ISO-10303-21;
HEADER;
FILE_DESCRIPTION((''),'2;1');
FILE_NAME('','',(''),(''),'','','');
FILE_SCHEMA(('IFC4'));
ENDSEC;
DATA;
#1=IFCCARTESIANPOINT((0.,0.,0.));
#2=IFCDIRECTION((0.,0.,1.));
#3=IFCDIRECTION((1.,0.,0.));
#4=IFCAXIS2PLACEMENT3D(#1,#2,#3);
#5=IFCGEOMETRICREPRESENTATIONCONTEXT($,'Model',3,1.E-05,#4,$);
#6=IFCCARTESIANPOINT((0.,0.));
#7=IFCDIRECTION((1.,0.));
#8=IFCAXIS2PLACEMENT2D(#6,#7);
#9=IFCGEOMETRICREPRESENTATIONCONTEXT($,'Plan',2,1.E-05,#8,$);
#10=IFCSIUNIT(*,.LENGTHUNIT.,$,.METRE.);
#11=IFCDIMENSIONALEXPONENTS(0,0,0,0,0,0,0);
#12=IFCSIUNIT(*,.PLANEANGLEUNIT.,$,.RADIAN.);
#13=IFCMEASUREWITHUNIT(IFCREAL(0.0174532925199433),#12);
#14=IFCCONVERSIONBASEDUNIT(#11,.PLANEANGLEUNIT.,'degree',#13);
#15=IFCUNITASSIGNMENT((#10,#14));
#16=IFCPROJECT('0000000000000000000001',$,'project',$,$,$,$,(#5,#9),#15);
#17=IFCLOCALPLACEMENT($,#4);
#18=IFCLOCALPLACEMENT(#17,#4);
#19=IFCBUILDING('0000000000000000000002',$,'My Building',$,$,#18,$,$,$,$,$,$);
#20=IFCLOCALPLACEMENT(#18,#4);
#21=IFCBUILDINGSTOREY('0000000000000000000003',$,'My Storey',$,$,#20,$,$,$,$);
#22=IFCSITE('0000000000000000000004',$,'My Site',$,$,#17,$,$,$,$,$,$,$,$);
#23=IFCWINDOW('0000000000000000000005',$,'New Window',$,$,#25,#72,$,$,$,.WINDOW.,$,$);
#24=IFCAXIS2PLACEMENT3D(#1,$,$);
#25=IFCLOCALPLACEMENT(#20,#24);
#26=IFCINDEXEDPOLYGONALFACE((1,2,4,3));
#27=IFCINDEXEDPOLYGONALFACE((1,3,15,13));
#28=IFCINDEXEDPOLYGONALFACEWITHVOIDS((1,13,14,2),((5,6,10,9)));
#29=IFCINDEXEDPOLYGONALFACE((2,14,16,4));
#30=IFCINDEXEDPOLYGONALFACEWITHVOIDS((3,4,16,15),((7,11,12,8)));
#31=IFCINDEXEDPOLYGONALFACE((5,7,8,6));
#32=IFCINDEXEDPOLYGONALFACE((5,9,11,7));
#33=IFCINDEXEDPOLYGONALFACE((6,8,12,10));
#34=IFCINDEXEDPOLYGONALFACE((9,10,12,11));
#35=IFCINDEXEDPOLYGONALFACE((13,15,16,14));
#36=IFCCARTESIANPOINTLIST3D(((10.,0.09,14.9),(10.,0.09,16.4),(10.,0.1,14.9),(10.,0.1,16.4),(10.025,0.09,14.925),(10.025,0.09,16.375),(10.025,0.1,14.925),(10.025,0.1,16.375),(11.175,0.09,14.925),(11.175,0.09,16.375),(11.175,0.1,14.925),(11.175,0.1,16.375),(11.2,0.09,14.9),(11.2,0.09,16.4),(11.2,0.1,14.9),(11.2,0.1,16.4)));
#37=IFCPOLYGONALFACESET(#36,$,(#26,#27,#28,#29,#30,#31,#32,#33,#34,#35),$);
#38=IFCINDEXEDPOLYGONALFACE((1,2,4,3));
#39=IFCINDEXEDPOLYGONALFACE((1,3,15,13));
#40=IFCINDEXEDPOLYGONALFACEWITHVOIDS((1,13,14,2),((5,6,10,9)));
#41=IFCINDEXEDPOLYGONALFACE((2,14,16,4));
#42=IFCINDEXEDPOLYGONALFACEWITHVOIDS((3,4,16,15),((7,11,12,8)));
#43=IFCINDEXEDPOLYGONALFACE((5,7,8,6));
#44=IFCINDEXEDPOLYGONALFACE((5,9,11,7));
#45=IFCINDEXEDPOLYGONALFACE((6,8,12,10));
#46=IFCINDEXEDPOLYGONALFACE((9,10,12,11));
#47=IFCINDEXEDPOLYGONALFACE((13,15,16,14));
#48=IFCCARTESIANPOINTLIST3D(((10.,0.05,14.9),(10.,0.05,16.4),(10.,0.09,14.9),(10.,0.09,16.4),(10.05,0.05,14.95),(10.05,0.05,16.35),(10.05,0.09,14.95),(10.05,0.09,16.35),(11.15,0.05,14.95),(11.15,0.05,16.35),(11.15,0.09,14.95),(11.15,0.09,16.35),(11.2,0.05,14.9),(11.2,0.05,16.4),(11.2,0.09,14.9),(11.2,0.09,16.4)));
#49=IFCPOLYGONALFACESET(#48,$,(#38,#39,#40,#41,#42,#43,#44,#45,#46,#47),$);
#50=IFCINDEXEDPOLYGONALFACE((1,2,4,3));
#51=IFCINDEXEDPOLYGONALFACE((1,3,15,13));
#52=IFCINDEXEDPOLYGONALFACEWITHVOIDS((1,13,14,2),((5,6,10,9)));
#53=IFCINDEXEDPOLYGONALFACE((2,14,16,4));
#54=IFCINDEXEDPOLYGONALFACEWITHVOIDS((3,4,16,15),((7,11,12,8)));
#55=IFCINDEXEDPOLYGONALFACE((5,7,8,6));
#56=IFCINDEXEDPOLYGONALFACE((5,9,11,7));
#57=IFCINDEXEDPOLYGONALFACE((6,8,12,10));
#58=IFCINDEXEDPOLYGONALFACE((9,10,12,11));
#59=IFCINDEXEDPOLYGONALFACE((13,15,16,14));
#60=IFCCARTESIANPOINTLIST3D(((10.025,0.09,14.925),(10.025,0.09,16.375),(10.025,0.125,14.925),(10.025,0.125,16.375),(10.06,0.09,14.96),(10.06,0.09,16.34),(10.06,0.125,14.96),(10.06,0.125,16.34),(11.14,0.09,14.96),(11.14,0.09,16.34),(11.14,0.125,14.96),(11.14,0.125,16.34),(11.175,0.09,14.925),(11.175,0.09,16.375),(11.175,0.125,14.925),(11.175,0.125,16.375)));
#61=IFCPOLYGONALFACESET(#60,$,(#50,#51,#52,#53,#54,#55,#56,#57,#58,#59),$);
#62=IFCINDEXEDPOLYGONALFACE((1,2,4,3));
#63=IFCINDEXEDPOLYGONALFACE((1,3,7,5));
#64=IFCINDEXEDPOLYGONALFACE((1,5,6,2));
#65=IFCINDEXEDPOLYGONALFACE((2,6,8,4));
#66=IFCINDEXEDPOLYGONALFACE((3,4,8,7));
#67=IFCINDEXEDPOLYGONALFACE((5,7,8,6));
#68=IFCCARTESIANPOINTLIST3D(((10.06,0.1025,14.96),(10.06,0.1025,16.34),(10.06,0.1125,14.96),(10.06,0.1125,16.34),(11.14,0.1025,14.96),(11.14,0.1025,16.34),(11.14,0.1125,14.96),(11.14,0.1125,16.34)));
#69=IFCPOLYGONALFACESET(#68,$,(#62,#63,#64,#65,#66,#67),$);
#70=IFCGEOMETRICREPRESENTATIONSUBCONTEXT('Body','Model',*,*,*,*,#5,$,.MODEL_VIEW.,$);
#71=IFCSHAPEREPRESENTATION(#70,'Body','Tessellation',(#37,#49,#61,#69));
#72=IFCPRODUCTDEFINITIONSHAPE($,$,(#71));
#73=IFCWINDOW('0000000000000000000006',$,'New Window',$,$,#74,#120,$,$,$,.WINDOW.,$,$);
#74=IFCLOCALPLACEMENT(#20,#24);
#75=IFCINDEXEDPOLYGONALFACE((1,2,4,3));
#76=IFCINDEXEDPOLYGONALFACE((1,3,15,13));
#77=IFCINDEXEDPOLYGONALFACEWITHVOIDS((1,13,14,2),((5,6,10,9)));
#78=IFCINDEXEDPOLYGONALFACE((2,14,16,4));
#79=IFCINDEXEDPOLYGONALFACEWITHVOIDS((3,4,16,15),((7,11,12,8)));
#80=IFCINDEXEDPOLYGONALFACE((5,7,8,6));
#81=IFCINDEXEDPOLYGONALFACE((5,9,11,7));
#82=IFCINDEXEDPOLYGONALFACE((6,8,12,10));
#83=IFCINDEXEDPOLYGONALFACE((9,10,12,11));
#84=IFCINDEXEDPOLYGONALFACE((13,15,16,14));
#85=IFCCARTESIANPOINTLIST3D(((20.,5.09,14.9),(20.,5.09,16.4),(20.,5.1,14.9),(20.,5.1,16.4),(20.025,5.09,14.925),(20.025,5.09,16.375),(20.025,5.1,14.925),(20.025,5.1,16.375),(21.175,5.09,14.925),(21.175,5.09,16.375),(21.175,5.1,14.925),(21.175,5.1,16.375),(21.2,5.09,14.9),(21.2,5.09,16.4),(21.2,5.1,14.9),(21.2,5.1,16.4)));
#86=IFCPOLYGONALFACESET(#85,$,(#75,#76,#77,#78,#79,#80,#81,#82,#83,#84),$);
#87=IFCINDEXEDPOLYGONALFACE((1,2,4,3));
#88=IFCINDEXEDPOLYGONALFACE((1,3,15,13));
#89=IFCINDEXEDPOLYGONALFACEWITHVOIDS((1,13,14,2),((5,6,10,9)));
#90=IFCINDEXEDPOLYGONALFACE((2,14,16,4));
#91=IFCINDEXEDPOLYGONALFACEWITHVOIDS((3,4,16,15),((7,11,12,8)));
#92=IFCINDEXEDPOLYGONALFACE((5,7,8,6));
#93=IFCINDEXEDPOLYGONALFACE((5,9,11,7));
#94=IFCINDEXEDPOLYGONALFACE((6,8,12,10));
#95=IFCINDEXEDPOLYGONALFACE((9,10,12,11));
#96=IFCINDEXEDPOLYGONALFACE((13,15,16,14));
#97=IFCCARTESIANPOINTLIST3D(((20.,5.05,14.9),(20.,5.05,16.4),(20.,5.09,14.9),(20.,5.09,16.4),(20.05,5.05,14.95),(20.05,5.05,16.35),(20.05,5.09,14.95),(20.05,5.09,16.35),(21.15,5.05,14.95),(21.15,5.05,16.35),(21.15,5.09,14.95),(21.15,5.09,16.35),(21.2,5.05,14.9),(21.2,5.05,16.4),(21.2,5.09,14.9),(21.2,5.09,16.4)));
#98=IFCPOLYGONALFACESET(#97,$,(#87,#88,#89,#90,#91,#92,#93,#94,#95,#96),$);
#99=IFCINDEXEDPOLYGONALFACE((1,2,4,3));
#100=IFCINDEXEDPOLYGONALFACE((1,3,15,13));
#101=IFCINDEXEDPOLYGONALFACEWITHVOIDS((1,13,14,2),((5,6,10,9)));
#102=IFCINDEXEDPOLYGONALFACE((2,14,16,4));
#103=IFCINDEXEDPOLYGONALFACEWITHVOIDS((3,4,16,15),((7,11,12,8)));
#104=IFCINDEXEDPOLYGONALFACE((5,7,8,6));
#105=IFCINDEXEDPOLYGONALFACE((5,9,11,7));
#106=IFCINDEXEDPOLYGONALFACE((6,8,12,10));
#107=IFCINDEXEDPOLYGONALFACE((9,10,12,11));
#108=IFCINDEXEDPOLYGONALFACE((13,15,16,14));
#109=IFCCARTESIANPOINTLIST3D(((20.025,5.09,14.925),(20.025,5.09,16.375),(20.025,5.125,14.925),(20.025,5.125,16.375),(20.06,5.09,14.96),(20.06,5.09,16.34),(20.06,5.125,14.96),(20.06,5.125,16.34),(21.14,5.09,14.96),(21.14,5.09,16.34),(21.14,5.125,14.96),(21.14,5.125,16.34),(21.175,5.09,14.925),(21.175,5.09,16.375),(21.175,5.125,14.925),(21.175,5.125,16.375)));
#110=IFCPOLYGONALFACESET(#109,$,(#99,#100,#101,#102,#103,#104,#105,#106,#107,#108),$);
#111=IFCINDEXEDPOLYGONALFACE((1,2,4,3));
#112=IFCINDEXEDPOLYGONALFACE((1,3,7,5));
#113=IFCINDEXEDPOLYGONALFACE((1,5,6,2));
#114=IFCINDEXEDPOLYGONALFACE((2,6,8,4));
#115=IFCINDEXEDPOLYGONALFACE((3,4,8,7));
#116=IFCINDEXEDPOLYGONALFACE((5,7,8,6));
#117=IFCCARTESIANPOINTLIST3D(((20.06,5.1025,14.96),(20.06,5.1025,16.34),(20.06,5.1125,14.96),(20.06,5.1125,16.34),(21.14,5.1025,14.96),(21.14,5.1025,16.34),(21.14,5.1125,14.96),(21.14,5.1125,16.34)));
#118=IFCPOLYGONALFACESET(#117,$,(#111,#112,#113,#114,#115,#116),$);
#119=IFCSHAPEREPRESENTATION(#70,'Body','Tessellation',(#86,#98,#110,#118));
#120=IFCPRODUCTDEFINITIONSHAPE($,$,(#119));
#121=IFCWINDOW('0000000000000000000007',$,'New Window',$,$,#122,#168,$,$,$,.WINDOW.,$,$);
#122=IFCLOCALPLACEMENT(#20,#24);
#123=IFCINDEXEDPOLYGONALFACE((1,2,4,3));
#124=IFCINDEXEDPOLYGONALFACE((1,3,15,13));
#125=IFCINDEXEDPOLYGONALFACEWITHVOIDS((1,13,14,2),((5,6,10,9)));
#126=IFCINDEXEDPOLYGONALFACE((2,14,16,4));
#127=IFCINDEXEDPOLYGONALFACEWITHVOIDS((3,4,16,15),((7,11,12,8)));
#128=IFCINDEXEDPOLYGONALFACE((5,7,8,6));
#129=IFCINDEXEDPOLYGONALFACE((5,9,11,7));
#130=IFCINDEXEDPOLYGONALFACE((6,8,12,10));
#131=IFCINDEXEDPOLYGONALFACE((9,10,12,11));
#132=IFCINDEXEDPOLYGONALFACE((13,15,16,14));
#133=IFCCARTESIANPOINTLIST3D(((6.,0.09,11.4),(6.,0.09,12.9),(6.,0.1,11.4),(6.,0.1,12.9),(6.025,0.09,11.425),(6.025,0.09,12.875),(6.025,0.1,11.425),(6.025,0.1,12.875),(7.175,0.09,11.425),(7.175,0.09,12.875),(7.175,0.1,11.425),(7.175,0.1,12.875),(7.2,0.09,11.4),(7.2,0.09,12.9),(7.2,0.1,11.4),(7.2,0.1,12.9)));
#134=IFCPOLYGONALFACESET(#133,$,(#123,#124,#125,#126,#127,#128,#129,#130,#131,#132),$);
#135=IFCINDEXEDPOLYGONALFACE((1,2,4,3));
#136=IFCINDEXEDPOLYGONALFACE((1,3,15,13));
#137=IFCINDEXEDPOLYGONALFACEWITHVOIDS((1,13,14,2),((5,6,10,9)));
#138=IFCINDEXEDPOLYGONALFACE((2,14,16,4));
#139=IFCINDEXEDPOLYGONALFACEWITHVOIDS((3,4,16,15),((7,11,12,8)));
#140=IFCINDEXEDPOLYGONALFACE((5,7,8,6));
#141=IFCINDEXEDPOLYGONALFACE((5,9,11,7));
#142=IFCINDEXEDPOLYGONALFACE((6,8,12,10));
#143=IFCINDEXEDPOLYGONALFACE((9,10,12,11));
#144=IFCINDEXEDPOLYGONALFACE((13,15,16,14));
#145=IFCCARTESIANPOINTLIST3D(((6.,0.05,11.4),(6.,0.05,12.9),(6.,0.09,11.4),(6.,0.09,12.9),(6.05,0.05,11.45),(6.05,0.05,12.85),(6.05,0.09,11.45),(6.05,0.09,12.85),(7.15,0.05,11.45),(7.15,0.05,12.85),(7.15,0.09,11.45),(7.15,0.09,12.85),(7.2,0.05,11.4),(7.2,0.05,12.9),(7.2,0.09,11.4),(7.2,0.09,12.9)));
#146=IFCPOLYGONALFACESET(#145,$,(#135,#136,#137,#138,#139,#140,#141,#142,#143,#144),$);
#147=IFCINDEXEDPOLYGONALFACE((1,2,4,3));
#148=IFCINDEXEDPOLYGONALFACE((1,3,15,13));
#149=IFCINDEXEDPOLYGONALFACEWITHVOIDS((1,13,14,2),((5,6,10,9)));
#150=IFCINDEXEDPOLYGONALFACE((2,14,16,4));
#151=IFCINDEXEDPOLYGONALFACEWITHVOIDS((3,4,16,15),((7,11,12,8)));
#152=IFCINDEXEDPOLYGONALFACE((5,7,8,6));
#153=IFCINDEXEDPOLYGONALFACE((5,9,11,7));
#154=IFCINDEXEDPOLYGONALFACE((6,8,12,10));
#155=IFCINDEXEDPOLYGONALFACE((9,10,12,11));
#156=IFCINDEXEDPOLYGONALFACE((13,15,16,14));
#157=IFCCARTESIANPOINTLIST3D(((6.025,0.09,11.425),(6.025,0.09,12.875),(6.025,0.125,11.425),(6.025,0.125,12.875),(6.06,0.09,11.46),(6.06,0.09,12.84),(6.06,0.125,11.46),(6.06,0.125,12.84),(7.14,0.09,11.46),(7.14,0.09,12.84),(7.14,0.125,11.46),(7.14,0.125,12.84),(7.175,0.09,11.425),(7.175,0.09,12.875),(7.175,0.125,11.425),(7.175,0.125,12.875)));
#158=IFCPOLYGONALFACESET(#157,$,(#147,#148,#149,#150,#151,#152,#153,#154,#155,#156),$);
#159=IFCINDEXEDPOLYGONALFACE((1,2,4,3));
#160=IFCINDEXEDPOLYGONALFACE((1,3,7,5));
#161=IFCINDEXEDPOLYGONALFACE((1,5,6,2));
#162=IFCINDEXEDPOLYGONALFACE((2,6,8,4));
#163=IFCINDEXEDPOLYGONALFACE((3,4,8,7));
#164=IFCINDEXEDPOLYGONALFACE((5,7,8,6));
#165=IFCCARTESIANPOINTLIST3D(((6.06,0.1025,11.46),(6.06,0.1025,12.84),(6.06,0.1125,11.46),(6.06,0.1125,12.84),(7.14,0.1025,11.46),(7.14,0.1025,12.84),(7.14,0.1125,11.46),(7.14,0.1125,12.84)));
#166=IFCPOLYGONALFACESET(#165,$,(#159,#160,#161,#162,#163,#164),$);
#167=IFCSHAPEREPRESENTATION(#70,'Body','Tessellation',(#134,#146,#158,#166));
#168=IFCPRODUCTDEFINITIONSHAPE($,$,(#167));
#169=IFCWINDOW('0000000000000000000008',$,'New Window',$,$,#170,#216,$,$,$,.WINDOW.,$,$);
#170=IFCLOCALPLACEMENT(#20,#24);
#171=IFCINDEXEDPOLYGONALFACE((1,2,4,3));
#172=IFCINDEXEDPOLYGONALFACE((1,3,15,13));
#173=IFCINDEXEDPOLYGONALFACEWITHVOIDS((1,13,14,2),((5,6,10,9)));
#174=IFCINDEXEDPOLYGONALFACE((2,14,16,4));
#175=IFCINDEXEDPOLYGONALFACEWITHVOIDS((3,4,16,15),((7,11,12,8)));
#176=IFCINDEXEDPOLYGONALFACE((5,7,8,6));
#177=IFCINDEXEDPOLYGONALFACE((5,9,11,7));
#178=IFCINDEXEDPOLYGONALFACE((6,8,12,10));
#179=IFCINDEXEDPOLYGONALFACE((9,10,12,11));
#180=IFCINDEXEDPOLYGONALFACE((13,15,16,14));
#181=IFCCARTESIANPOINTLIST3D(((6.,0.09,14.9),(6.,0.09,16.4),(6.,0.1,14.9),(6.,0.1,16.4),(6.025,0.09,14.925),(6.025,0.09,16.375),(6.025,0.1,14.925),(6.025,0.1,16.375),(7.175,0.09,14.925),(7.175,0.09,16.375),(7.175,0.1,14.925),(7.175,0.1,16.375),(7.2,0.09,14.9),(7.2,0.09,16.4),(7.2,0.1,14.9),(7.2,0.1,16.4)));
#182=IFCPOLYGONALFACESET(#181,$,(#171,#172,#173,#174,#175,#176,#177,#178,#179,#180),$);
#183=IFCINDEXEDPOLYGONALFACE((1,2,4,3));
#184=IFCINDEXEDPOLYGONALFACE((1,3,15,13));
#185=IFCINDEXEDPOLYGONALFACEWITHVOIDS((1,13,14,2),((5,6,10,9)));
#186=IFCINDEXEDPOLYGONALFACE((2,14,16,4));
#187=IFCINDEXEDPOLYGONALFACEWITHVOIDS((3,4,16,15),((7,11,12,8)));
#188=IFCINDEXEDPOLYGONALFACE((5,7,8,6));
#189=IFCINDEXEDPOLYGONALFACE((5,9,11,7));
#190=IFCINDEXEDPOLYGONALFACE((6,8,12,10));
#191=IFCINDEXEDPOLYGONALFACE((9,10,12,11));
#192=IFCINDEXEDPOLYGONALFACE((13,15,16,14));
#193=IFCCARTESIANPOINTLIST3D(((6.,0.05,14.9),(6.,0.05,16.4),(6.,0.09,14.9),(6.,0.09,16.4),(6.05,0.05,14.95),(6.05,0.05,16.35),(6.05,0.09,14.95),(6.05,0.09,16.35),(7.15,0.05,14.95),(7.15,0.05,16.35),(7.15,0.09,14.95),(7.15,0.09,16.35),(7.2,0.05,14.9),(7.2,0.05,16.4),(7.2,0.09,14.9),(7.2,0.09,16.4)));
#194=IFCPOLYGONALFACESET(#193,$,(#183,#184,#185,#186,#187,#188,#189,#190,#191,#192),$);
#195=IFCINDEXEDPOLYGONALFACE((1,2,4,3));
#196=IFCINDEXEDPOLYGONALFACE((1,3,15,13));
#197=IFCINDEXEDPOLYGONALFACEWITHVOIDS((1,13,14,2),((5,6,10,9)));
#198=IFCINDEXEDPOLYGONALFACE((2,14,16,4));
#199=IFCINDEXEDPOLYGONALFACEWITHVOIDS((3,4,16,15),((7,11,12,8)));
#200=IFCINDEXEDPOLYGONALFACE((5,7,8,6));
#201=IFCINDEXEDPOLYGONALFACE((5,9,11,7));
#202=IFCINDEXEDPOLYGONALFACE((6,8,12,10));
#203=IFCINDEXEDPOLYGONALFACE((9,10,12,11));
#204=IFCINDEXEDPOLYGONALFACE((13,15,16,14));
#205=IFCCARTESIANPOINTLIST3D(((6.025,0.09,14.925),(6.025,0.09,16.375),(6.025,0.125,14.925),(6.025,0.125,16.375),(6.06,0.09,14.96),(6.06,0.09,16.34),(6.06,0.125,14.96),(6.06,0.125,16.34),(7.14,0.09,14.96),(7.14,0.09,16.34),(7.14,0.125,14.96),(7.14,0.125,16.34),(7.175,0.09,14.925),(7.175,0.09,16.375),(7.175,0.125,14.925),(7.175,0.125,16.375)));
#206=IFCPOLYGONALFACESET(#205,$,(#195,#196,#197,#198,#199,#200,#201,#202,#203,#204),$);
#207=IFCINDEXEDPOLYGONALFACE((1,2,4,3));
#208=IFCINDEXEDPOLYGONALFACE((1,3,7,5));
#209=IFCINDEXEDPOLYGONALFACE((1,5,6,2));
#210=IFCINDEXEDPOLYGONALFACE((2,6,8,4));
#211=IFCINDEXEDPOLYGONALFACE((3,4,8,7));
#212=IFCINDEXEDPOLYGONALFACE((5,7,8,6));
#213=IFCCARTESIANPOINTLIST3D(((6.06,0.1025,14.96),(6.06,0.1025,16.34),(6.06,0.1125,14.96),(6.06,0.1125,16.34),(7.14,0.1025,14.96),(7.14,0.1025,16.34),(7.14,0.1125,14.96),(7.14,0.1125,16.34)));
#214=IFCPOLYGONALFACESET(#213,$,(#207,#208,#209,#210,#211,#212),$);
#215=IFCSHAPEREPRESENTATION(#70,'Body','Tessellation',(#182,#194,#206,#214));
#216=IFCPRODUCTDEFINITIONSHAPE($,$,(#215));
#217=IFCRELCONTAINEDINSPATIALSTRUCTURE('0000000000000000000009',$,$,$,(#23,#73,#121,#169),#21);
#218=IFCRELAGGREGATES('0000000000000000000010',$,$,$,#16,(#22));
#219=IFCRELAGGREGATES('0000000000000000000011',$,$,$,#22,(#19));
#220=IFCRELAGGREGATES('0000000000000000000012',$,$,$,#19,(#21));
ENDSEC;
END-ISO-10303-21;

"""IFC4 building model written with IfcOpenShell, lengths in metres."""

from ifc_helpers import new_model, entity, si_unit, converted_unit, frame, origin_with_axes, origin_2d_with_axis, place, context, subcontext, project, spatial, line, indexed_curve, outline, extrude, element, save


model = new_model("IFC4")

# Units and contexts
model_context = context("Model", 3, precision=1e-05, world=origin_with_axes())
plan_context = context("Plan", 2, precision=1e-05, world=origin_2d_with_axis())
body_context = subcontext(model_context, "Body", "Model", "MODEL_VIEW")
ifc_project = project(units=[si_unit("LENGTHUNIT", "METRE"), converted_unit("PLANEANGLEUNIT", "degree", entity("IfcReal", 0.0174532925199433), si_unit("PLANEANGLEUNIT", "RADIAN"), dimensions=[0, 0, 0, 0, 0, 0, 0])], contexts=[model_context, plan_context])

# Site, building, storey
site_placement = place(None, origin_with_axes())
site = spatial("IfcSite", under=ifc_project, at=site_placement, Name="My Site")
building_placement = place(site_placement, origin_with_axes())
building = spatial("IfcBuilding", under=site, at=building_placement, Name="My Building")
storey_placement = place(building_placement, origin_with_axes())
storey = spatial("IfcBuildingStorey", under=building, at=storey_placement, Name="My Storey")

# Windows
for number, where, z_axis, x_axis, name in (
    (1, (10.0, 0.0, 14.9), (0.0, 0.0, 1.0), (1.0, 0.0, 0.0), "New Window"),
    (2, (20.0, 5.0, 14.9), (0.0, 0.0, 1.0), (1.0, 0.0, 0.0), "New Window"),
):
    element("IfcWindow", number, at=place(storey_placement, frame(where, z_axis=z_axis, x_axis=x_axis)), inside=storey, Name=name, PredefinedType="WINDOW", context=body_context, shape_type="SweptSolid", body=[
        extrude(outline(indexed_curve([(0.0, 0.0), (1.2, 0.0), (1.2, 1.5), (0.0, 1.5)], segments=[line(1, 2, 3, 4, 1)]), holes=[indexed_curve([(0.025, 0.025), (1.175, 0.025), (1.175, 1.475), (0.025, 1.475)], segments=[line(1, 2, 3, 4, 1)])]), frame((0.0, 0.09, 0.0), z_axis=(0.0, -1.0, 0.0), x_axis=(1.0, 0.0, 0.0)), (0.0, 0.0, -1.0), 0.01),
        extrude(outline(indexed_curve([(0.0, 0.0), (1.2, 0.0), (1.2, 1.5), (0.0, 1.5)], segments=[line(1, 2, 3, 4, 1)]), holes=[indexed_curve([(0.05, 0.05), (1.15, 0.05), (1.15, 1.45), (0.05, 1.45)], segments=[line(1, 2, 3, 4, 1)])]), frame((0.0, 0.05, 0.0), z_axis=(0.0, -1.0, 0.0), x_axis=(1.0, 0.0, 0.0)), (0.0, 0.0, -1.0), 0.04),
        extrude(outline(indexed_curve([(0.0, 0.0), (1.15, 0.0), (1.15, 1.45), (0.0, 1.45)], segments=[line(1, 2, 3, 4, 1)]), holes=[indexed_curve([(0.035, 0.035), (1.115, 0.035), (1.115, 1.415), (0.035, 1.415)], segments=[line(1, 2, 3, 4, 1)])]), frame((0.025, 0.09, 0.025), z_axis=(0.0, -1.0, 0.0), x_axis=(1.0, 0.0, 0.0)), (0.0, 0.0, -1.0), 0.035),
        extrude(outline(indexed_curve([(0.035, 0.035), (1.115, 0.035), (1.115, 1.415), (0.035, 1.415)], segments=[line(1, 2, 3, 4, 1)])), frame((0.025, 0.1025, 0.025), z_axis=(0.0, -1.0, 0.0), x_axis=(1.0, 0.0, 0.0)), (0.0, 0.0, -1.0), 0.01),
    ])

# Windows
for number, where, z_axis, x_axis, name in (
    (3, (6.0, 0.0, 11.4), (0.0, 0.0, 1.0), (1.0, 0.0, 0.0), "New Window"),
    (4, (6.0, 0.0, 14.9), (0.0, 0.0, 1.0), (1.0, 0.0, 0.0), "New Window"),
):
    element("IfcWindow", number, at=place(storey_placement, frame(where, z_axis=z_axis, x_axis=x_axis)), inside=storey, Name=name, PredefinedType="WINDOW", context=body_context, shape_type="SweptSolid", body=[
        extrude(outline(indexed_curve([(0.0, 0.0), (1.2, 0.0), (1.2, 1.5), (0.0, 1.5)], segments=[line(1, 2, 3, 4, 1)]), holes=[indexed_curve([(0.025, 0.025), (1.175, 0.025), (1.175, 1.475), (0.025, 1.475)], segments=[line(1, 2, 3, 4, 1)])]), frame((0.0, 0.09, 0.0), z_axis=(0.0, -1.0, 0.0), x_axis=(1.0, 0.0, 0.0)), (0.0, 0.0, -1.0), 0.01),
        extrude(outline(indexed_curve([(0.0, 0.0), (1.2, 0.0), (1.2, 1.5), (0.0, 1.5)], segments=[line(1, 2, 3, 4, 1)]), holes=[indexed_curve([(0.05, 0.05), (1.15, 0.05), (1.15, 1.45), (0.05, 1.45)], segments=[line(1, 2, 3, 4, 1)])]), frame((0.0, 0.05, 0.0), z_axis=(0.0, -1.0, 0.0), x_axis=(1.0, 0.0, 0.0)), (0.0, 0.0, -1.0), 0.04),
        extrude(outline(indexed_curve([(0.0, 0.0), (1.15, 0.0), (1.15, 1.45), (0.0, 1.45)], segments=[line(1, 2, 3, 4, 1)]), holes=[indexed_curve([(0.035, 0.035), (1.115, 0.035), (1.115, 1.415), (0.035, 1.415)], segments=[line(1, 2, 3, 4, 1)])]), frame((0.025, 0.09, 0.025), z_axis=(0.0, -1.0, 0.0), x_axis=(1.0, 0.0, 0.0)), (0.0, 0.0, -1.0), 0.035),
        extrude(outline(indexed_curve([(0.035, 0.035), (1.115, 0.035), (1.115, 1.415), (0.035, 1.415)], segments=[line(1, 2, 3, 4, 1)])), frame((0.025, 0.1025, 0.025), z_axis=(0.0, -1.0, 0.0), x_axis=(1.0, 0.0, 0.0)), (0.0, 0.0, -1.0), 0.01),
    ])

save(model, "model.ifc")
